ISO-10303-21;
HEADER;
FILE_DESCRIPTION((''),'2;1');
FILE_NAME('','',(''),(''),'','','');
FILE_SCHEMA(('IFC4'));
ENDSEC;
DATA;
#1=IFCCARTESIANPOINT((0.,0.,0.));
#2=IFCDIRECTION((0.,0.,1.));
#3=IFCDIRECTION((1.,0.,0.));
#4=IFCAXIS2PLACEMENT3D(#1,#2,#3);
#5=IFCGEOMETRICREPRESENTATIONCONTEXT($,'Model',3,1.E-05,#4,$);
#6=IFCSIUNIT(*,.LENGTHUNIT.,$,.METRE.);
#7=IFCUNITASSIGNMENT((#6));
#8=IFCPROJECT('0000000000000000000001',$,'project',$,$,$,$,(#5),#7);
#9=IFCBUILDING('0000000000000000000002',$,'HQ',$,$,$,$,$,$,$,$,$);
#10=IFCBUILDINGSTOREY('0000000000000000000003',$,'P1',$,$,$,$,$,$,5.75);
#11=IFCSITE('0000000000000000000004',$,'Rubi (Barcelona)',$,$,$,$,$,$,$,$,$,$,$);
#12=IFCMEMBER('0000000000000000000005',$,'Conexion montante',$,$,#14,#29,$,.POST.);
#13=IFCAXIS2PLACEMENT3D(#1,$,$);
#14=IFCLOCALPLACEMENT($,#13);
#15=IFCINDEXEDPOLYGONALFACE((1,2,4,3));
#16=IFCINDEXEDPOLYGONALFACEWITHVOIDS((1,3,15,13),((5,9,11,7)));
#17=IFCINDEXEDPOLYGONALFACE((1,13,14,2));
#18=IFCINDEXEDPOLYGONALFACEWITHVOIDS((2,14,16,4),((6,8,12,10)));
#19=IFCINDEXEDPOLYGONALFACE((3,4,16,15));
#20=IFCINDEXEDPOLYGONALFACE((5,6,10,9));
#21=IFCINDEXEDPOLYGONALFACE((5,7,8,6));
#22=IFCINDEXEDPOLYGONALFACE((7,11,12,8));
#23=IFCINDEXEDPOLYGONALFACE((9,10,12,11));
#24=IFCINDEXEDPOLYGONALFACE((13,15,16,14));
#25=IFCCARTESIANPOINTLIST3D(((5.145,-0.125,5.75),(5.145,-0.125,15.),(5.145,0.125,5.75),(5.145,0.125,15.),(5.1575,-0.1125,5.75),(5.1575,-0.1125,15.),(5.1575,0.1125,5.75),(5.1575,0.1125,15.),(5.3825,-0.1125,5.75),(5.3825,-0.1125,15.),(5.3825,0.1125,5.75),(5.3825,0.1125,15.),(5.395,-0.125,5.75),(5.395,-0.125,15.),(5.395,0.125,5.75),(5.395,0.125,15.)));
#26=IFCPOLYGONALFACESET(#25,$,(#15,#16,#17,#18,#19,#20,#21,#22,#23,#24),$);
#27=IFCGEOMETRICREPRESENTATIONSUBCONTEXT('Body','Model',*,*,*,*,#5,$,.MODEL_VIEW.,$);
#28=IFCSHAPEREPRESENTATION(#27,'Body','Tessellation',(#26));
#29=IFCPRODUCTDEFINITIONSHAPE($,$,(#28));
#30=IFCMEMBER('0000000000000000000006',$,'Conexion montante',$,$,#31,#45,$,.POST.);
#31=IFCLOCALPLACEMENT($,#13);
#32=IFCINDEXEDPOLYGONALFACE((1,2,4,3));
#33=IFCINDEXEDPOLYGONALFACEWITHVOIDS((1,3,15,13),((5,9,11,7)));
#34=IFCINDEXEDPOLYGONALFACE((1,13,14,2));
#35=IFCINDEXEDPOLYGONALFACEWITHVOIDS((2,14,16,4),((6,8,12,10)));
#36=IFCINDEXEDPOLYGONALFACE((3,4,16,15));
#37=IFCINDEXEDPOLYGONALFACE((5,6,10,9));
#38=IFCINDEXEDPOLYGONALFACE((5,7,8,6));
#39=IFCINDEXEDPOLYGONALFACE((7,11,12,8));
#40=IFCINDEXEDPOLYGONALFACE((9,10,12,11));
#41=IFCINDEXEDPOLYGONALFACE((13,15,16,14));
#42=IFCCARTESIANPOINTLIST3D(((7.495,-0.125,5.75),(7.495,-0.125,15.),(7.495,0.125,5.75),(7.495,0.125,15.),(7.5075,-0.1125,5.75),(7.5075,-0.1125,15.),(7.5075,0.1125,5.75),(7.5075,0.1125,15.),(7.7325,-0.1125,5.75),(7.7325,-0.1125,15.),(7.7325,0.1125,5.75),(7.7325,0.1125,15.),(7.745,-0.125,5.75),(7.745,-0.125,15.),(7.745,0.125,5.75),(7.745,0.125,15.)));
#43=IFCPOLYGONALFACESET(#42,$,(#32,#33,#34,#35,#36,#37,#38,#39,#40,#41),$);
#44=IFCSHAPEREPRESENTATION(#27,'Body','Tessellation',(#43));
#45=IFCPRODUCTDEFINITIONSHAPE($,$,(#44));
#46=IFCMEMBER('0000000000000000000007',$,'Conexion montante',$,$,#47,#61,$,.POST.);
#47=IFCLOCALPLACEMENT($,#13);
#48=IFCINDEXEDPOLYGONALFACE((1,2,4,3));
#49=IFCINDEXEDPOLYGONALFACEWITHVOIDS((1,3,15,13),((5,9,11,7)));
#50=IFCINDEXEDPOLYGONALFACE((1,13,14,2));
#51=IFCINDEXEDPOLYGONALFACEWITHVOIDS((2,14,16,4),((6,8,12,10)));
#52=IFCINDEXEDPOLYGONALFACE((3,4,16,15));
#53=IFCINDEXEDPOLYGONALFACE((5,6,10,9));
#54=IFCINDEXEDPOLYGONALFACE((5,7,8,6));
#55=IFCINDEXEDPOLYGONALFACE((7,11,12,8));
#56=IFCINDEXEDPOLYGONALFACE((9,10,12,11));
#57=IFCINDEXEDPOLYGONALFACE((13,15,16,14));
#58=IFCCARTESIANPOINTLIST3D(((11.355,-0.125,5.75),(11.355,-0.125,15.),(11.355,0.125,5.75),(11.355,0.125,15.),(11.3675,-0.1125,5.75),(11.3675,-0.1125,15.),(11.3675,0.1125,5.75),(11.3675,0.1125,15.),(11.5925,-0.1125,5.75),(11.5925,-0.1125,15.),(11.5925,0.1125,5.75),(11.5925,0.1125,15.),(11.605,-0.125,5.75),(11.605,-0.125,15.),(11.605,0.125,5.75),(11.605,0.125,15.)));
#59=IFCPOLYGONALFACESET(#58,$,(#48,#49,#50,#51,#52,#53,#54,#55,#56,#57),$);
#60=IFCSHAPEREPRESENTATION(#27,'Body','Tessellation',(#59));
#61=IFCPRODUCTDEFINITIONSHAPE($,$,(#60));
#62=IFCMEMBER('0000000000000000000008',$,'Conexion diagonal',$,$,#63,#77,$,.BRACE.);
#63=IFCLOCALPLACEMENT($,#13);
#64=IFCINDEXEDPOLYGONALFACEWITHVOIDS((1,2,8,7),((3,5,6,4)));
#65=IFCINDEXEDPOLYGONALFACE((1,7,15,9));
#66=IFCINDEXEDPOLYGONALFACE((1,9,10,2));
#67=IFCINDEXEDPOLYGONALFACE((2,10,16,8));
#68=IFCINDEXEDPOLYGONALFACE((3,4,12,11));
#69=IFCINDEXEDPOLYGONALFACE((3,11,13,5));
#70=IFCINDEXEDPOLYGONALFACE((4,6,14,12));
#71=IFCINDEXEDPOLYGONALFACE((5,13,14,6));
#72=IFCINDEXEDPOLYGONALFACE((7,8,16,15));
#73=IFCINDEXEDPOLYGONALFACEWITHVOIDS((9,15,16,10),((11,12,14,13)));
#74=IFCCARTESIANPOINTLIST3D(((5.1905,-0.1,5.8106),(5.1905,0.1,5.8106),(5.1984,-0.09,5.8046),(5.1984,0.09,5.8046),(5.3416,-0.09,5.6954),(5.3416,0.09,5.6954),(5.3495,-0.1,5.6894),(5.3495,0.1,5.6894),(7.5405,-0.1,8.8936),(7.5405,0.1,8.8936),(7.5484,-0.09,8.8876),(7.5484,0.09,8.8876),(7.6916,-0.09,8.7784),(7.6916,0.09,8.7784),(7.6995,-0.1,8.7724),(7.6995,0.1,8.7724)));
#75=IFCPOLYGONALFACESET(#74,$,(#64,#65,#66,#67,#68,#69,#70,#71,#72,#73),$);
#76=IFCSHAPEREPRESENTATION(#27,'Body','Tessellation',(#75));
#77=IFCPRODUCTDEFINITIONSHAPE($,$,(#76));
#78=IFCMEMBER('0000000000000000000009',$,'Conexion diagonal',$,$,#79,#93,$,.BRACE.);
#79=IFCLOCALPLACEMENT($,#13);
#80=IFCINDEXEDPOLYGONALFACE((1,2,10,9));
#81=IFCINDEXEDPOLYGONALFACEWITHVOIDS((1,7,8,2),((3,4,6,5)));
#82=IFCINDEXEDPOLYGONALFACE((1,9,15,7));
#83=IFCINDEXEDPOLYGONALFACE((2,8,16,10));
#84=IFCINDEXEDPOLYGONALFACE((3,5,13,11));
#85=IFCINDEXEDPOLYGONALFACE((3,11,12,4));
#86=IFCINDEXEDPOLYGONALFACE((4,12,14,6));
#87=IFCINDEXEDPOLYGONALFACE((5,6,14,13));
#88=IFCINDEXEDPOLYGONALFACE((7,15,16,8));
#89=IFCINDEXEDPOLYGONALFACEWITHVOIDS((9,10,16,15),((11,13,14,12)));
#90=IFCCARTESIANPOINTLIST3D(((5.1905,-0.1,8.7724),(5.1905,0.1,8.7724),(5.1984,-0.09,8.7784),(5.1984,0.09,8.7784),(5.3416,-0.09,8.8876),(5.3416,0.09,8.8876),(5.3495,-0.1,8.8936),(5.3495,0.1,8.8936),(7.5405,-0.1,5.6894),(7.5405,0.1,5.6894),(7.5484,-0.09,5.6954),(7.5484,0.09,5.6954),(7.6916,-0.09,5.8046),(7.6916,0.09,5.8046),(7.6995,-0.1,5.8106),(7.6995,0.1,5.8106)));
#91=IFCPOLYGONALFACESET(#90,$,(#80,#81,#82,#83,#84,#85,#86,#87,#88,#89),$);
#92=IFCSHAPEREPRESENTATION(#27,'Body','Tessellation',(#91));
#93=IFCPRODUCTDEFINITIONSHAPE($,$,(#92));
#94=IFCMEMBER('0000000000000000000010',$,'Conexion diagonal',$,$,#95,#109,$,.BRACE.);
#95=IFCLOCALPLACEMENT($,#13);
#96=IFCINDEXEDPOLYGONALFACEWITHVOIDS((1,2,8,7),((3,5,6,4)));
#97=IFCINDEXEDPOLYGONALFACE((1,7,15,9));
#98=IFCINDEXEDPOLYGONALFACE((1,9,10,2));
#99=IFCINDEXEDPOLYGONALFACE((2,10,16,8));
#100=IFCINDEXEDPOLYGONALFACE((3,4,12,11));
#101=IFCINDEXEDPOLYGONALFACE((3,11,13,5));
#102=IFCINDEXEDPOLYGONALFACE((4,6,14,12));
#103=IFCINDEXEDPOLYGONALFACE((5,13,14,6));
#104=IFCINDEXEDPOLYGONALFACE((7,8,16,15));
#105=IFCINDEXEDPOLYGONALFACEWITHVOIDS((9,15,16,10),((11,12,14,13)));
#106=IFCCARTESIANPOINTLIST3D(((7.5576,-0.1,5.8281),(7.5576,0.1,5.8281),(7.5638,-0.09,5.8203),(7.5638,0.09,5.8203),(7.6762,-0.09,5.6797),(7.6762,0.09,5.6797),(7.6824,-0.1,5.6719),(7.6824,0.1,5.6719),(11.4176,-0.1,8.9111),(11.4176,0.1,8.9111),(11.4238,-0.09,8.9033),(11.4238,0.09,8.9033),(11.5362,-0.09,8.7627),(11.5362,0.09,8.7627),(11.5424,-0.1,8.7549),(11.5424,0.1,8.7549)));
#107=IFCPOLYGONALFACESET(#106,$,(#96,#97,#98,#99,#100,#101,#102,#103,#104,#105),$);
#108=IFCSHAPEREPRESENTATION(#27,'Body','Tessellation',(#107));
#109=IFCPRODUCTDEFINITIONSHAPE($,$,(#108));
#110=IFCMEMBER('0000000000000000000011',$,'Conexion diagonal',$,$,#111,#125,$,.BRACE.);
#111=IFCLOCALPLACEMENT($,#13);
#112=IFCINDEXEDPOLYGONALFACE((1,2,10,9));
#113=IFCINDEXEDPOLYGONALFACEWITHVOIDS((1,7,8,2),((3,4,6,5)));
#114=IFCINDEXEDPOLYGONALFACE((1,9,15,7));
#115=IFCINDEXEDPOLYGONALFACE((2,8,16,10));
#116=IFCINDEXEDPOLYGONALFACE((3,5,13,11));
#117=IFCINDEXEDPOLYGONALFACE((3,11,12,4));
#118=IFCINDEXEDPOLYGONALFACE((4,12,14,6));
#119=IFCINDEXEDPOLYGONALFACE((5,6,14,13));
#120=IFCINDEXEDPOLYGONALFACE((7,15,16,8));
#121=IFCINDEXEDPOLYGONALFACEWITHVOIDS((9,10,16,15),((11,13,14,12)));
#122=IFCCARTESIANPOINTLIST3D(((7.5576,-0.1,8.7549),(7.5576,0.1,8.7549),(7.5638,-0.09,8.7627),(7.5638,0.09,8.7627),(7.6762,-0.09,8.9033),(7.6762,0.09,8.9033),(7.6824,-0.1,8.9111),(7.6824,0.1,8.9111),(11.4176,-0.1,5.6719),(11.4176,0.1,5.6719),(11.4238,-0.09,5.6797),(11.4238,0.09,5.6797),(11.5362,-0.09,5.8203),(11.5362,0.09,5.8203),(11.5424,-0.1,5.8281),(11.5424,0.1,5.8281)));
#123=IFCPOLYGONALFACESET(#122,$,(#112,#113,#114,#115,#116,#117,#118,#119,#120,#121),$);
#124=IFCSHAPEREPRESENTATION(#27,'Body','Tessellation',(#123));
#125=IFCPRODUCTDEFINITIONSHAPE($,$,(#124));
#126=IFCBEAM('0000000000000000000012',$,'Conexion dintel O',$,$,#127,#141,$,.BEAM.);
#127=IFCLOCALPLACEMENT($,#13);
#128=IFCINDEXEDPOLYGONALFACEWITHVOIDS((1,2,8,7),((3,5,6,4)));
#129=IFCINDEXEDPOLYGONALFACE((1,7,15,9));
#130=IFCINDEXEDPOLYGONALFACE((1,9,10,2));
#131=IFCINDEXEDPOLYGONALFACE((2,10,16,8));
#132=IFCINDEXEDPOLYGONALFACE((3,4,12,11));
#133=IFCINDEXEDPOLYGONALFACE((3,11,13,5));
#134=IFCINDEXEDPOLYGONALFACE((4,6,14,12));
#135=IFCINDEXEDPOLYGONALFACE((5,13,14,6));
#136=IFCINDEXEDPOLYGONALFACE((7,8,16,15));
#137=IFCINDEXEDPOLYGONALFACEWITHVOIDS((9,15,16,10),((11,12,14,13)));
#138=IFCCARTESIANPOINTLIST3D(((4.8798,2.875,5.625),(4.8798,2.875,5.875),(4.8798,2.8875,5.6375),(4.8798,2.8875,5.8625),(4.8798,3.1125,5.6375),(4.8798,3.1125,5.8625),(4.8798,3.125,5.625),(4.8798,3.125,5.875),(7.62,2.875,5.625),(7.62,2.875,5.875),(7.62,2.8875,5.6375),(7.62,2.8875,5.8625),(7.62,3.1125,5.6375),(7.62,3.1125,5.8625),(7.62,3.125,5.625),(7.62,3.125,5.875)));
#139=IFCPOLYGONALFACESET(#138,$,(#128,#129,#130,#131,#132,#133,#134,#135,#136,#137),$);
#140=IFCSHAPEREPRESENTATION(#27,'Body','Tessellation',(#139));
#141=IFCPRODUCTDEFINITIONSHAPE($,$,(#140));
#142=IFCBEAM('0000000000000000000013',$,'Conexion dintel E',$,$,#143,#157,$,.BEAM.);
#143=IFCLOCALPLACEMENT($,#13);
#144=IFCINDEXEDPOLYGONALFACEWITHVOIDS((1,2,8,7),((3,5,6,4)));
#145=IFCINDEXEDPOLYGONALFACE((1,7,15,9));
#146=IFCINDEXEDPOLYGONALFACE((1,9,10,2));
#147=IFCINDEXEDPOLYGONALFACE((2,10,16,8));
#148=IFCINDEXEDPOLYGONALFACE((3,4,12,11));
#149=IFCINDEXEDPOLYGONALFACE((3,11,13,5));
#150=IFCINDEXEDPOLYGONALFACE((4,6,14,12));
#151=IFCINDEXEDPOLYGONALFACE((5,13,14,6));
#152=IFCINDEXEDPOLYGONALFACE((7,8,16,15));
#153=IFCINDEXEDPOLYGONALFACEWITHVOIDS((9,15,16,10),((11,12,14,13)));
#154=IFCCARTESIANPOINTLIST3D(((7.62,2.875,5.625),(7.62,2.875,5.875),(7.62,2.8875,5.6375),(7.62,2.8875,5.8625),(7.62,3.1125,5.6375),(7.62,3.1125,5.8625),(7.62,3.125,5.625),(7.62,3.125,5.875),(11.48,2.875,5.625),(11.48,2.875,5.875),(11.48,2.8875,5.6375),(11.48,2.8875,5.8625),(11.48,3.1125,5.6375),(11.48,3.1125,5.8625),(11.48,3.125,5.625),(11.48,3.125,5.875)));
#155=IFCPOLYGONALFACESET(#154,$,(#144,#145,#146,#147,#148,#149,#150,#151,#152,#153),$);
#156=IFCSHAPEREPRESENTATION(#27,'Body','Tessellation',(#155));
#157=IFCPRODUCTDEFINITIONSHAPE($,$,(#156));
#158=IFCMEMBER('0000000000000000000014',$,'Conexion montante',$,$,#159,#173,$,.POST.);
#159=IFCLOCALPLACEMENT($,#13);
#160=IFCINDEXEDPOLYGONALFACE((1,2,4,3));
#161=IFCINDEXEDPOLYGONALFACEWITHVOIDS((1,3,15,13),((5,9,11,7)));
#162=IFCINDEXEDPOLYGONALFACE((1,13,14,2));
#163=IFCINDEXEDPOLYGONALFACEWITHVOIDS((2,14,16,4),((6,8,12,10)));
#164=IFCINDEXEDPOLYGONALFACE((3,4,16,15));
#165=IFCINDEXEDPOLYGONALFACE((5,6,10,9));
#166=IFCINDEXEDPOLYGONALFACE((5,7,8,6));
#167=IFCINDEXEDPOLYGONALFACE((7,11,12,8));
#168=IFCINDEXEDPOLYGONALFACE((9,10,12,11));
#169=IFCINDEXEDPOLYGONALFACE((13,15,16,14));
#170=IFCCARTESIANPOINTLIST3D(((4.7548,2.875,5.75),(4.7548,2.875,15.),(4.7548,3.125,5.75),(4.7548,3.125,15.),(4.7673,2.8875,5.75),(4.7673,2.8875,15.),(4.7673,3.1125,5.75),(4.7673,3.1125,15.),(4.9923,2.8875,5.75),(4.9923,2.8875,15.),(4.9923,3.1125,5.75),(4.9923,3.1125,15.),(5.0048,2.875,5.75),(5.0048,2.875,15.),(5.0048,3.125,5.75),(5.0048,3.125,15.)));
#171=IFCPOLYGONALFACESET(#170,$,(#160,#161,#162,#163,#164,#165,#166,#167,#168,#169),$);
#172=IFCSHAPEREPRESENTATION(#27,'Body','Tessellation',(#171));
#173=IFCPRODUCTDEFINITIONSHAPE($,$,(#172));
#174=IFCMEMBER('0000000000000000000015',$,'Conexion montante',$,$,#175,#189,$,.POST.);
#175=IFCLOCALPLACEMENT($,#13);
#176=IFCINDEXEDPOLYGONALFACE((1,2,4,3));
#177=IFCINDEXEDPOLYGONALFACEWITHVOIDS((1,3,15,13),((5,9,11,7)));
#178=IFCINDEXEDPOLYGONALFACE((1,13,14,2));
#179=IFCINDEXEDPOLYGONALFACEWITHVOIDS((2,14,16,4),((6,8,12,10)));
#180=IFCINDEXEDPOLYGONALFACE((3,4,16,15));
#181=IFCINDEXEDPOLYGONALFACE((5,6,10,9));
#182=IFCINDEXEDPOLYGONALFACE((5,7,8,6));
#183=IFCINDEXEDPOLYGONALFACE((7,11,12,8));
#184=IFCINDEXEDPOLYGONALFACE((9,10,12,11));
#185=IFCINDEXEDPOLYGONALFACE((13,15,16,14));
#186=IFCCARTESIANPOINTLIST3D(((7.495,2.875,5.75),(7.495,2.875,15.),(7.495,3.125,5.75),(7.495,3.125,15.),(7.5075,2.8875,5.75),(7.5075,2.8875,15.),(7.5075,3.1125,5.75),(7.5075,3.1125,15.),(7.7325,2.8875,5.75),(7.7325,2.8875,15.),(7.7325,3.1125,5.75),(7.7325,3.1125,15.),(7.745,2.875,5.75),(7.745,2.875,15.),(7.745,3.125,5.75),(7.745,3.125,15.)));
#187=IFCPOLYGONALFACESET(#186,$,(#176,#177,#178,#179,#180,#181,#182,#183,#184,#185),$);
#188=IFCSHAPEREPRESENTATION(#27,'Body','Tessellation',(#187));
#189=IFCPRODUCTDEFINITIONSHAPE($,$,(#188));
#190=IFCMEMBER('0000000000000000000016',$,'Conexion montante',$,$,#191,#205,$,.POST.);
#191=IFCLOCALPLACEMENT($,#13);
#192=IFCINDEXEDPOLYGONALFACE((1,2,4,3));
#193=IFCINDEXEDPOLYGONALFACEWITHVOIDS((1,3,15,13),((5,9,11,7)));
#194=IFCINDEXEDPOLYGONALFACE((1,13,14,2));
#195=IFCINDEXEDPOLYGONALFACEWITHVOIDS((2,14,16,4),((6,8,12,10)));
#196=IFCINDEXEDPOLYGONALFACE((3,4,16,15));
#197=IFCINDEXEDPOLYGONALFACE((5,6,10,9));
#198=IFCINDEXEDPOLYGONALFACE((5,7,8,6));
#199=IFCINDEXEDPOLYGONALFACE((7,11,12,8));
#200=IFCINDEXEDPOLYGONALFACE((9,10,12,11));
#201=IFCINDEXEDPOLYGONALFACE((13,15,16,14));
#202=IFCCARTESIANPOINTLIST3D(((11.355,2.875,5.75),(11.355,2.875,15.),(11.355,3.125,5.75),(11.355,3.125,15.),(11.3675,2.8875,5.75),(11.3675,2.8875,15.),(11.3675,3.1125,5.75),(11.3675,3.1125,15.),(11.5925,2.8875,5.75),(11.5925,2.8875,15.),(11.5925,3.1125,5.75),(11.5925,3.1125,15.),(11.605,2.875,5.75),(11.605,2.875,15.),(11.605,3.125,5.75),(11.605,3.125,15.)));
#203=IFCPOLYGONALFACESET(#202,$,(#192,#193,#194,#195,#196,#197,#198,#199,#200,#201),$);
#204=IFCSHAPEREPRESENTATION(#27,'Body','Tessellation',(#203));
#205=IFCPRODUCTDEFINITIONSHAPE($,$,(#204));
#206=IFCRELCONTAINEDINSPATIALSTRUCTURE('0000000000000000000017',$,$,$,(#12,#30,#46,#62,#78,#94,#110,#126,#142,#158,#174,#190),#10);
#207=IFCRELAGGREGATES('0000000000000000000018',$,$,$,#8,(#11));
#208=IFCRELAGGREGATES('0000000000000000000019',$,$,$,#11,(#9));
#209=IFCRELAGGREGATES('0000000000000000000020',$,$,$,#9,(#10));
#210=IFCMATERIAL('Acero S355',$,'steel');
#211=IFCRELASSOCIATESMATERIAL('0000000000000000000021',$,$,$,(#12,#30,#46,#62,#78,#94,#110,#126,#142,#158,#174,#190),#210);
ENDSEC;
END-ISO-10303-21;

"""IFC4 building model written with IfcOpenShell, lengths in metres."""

from ifc_helpers import new_model, si_unit, frame, origin_with_axes, place, context, subcontext, project, spatial, hollow_rectangle, extrude, material, element, save


model = new_model("IFC4")

# Units and contexts
model_context = context("Model", 3, precision=1e-05, world=origin_with_axes())
body_context = subcontext(model_context, "Body", "Model", "MODEL_VIEW")
ifc_project = project(units=[si_unit("LENGTHUNIT", "METRE")], contexts=[model_context])

# Site, building, storey
site = spatial("IfcSite", under=ifc_project, Name="Rubi (Barcelona)")
building = spatial("IfcBuilding", under=site, Name="HQ")
storey = spatial("IfcBuildingStorey", under=building, Name="P1", Elevation=5.75)

# Members
ifc_material = material(Name="Acero S355", Category="steel")
member_1_placement = place(None, origin_with_axes())
element("IfcMember", 1, at=member_1_placement, inside=storey, material=ifc_material, Name="Conexion montante", PredefinedType="POST", context=body_context, shape_type="SweptSolid", body=[
    extrude(hollow_rectangle(XDim=0.25, YDim=0.25, WallThickness=0.0125), frame((5.27, 0.0, 5.75), z_axis=(0.0, 0.0, 1.0), x_axis=(1.0, 0.0, 0.0)), (0.0, 0.0, 1.0), 9.25),
])
member_2_placement = place(None, origin_with_axes())
element("IfcMember", 2, at=member_2_placement, inside=storey, material=ifc_material, Name="Conexion montante", PredefinedType="POST", context=body_context, shape_type="SweptSolid", body=[
    extrude(hollow_rectangle(XDim=0.25, YDim=0.25, WallThickness=0.0125), frame((7.62, 0.0, 5.75), z_axis=(0.0, 0.0, 1.0), x_axis=(1.0, 0.0, 0.0)), (0.0, 0.0, 1.0), 9.25),
])
member_3_placement = place(None, origin_with_axes())
element("IfcMember", 3, at=member_3_placement, inside=storey, material=ifc_material, Name="Conexion montante", PredefinedType="POST", context=body_context, shape_type="SweptSolid", body=[
    extrude(hollow_rectangle(XDim=0.25, YDim=0.25, WallThickness=0.0125), frame((11.48, 0.0, 5.75), z_axis=(0.0, 0.0, 1.0), x_axis=(1.0, 0.0, 0.0)), (0.0, 0.0, 1.0), 9.25),
])
member_4_placement = place(None, origin_with_axes())
element("IfcMember", 4, at=member_4_placement, inside=storey, material=ifc_material, Name="Conexion diagonal", PredefinedType="BRACE", context=body_context, shape_type="SweptSolid", body=[
    extrude(hollow_rectangle(XDim=0.2, YDim=0.2, WallThickness=0.01), frame((5.27, 0.0, 5.75), z_axis=(0.606214, 0.0, 0.795301), x_axis=(0.0, 1.0, 0.0)), (0.0, 0.0, 1.0), 3.8765),
])
member_5_placement = place(None, origin_with_axes())
element("IfcMember", 5, at=member_5_placement, inside=storey, material=ifc_material, Name="Conexion diagonal", PredefinedType="BRACE", context=body_context, shape_type="SweptSolid", body=[
    extrude(hollow_rectangle(XDim=0.2, YDim=0.2, WallThickness=0.01), frame((7.62, 0.0, 5.75), z_axis=(-0.606214, 0.0, 0.795301), x_axis=(0.0, -1.0, 0.0)), (0.0, 0.0, 1.0), 3.8765),
])
member_6_placement = place(None, origin_with_axes())
element("IfcMember", 6, at=member_6_placement, inside=storey, material=ifc_material, Name="Conexion diagonal", PredefinedType="BRACE", context=body_context, shape_type="SweptSolid", body=[
    extrude(hollow_rectangle(XDim=0.2, YDim=0.2, WallThickness=0.01), frame((7.62, 0.0, 5.75), z_axis=(0.781362, 0.0, 0.624078), x_axis=(0.0, 1.0, 0.0)), (0.0, 0.0, 1.0), 4.9401),
])
member_7_placement = place(None, origin_with_axes())
element("IfcMember", 7, at=member_7_placement, inside=storey, material=ifc_material, Name="Conexion diagonal", PredefinedType="BRACE", context=body_context, shape_type="SweptSolid", body=[
    extrude(hollow_rectangle(XDim=0.2, YDim=0.2, WallThickness=0.01), frame((11.48, 0.0, 5.75), z_axis=(-0.781362, 0.0, 0.624078), x_axis=(0.0, -1.0, 0.0)), (0.0, 0.0, 1.0), 4.9401),
])

# Beams
beam_1_placement = place(None, origin_with_axes())
element("IfcBeam", 8, at=beam_1_placement, inside=storey, material=ifc_material, Name="Conexion dintel O", PredefinedType="BEAM", context=body_context, shape_type="SweptSolid", body=[
    extrude(hollow_rectangle(XDim=0.25, YDim=0.25, WallThickness=0.0125), frame((4.8798, 3.0, 5.75), z_axis=(1.0, 0.0, 0.0), x_axis=(0.0, 1.0, 0.0)), (0.0, 0.0, 1.0), 2.7402),
])
beam_2_placement = place(None, origin_with_axes())
element("IfcBeam", 9, at=beam_2_placement, inside=storey, material=ifc_material, Name="Conexion dintel E", PredefinedType="BEAM", context=body_context, shape_type="SweptSolid", body=[
    extrude(hollow_rectangle(XDim=0.25, YDim=0.25, WallThickness=0.0125), frame((7.62, 3.0, 5.75), z_axis=(1.0, 0.0, 0.0), x_axis=(0.0, 1.0, 0.0)), (0.0, 0.0, 1.0), 3.86),
])

# Members
member_8_placement = place(None, origin_with_axes())
element("IfcMember", 10, at=member_8_placement, inside=storey, material=ifc_material, Name="Conexion montante", PredefinedType="POST", context=body_context, shape_type="SweptSolid", body=[
    extrude(hollow_rectangle(XDim=0.25, YDim=0.25, WallThickness=0.0125), frame((4.8798, 3.0, 5.75), z_axis=(0.0, 0.0, 1.0), x_axis=(1.0, 0.0, 0.0)), (0.0, 0.0, 1.0), 9.25),
])
member_9_placement = place(None, origin_with_axes())
element("IfcMember", 11, at=member_9_placement, inside=storey, material=ifc_material, Name="Conexion montante", PredefinedType="POST", context=body_context, shape_type="SweptSolid", body=[
    extrude(hollow_rectangle(XDim=0.25, YDim=0.25, WallThickness=0.0125), frame((7.62, 3.0, 5.75), z_axis=(0.0, 0.0, 1.0), x_axis=(1.0, 0.0, 0.0)), (0.0, 0.0, 1.0), 9.25),
])
member_10_placement = place(None, origin_with_axes())
element("IfcMember", 12, at=member_10_placement, inside=storey, material=ifc_material, Name="Conexion montante", PredefinedType="POST", context=body_context, shape_type="SweptSolid", body=[
    extrude(hollow_rectangle(XDim=0.25, YDim=0.25, WallThickness=0.0125), frame((11.48, 3.0, 5.75), z_axis=(0.0, 0.0, 1.0), x_axis=(1.0, 0.0, 0.0)), (0.0, 0.0, 1.0), 9.25),
])

save(model, "model.ifc")
